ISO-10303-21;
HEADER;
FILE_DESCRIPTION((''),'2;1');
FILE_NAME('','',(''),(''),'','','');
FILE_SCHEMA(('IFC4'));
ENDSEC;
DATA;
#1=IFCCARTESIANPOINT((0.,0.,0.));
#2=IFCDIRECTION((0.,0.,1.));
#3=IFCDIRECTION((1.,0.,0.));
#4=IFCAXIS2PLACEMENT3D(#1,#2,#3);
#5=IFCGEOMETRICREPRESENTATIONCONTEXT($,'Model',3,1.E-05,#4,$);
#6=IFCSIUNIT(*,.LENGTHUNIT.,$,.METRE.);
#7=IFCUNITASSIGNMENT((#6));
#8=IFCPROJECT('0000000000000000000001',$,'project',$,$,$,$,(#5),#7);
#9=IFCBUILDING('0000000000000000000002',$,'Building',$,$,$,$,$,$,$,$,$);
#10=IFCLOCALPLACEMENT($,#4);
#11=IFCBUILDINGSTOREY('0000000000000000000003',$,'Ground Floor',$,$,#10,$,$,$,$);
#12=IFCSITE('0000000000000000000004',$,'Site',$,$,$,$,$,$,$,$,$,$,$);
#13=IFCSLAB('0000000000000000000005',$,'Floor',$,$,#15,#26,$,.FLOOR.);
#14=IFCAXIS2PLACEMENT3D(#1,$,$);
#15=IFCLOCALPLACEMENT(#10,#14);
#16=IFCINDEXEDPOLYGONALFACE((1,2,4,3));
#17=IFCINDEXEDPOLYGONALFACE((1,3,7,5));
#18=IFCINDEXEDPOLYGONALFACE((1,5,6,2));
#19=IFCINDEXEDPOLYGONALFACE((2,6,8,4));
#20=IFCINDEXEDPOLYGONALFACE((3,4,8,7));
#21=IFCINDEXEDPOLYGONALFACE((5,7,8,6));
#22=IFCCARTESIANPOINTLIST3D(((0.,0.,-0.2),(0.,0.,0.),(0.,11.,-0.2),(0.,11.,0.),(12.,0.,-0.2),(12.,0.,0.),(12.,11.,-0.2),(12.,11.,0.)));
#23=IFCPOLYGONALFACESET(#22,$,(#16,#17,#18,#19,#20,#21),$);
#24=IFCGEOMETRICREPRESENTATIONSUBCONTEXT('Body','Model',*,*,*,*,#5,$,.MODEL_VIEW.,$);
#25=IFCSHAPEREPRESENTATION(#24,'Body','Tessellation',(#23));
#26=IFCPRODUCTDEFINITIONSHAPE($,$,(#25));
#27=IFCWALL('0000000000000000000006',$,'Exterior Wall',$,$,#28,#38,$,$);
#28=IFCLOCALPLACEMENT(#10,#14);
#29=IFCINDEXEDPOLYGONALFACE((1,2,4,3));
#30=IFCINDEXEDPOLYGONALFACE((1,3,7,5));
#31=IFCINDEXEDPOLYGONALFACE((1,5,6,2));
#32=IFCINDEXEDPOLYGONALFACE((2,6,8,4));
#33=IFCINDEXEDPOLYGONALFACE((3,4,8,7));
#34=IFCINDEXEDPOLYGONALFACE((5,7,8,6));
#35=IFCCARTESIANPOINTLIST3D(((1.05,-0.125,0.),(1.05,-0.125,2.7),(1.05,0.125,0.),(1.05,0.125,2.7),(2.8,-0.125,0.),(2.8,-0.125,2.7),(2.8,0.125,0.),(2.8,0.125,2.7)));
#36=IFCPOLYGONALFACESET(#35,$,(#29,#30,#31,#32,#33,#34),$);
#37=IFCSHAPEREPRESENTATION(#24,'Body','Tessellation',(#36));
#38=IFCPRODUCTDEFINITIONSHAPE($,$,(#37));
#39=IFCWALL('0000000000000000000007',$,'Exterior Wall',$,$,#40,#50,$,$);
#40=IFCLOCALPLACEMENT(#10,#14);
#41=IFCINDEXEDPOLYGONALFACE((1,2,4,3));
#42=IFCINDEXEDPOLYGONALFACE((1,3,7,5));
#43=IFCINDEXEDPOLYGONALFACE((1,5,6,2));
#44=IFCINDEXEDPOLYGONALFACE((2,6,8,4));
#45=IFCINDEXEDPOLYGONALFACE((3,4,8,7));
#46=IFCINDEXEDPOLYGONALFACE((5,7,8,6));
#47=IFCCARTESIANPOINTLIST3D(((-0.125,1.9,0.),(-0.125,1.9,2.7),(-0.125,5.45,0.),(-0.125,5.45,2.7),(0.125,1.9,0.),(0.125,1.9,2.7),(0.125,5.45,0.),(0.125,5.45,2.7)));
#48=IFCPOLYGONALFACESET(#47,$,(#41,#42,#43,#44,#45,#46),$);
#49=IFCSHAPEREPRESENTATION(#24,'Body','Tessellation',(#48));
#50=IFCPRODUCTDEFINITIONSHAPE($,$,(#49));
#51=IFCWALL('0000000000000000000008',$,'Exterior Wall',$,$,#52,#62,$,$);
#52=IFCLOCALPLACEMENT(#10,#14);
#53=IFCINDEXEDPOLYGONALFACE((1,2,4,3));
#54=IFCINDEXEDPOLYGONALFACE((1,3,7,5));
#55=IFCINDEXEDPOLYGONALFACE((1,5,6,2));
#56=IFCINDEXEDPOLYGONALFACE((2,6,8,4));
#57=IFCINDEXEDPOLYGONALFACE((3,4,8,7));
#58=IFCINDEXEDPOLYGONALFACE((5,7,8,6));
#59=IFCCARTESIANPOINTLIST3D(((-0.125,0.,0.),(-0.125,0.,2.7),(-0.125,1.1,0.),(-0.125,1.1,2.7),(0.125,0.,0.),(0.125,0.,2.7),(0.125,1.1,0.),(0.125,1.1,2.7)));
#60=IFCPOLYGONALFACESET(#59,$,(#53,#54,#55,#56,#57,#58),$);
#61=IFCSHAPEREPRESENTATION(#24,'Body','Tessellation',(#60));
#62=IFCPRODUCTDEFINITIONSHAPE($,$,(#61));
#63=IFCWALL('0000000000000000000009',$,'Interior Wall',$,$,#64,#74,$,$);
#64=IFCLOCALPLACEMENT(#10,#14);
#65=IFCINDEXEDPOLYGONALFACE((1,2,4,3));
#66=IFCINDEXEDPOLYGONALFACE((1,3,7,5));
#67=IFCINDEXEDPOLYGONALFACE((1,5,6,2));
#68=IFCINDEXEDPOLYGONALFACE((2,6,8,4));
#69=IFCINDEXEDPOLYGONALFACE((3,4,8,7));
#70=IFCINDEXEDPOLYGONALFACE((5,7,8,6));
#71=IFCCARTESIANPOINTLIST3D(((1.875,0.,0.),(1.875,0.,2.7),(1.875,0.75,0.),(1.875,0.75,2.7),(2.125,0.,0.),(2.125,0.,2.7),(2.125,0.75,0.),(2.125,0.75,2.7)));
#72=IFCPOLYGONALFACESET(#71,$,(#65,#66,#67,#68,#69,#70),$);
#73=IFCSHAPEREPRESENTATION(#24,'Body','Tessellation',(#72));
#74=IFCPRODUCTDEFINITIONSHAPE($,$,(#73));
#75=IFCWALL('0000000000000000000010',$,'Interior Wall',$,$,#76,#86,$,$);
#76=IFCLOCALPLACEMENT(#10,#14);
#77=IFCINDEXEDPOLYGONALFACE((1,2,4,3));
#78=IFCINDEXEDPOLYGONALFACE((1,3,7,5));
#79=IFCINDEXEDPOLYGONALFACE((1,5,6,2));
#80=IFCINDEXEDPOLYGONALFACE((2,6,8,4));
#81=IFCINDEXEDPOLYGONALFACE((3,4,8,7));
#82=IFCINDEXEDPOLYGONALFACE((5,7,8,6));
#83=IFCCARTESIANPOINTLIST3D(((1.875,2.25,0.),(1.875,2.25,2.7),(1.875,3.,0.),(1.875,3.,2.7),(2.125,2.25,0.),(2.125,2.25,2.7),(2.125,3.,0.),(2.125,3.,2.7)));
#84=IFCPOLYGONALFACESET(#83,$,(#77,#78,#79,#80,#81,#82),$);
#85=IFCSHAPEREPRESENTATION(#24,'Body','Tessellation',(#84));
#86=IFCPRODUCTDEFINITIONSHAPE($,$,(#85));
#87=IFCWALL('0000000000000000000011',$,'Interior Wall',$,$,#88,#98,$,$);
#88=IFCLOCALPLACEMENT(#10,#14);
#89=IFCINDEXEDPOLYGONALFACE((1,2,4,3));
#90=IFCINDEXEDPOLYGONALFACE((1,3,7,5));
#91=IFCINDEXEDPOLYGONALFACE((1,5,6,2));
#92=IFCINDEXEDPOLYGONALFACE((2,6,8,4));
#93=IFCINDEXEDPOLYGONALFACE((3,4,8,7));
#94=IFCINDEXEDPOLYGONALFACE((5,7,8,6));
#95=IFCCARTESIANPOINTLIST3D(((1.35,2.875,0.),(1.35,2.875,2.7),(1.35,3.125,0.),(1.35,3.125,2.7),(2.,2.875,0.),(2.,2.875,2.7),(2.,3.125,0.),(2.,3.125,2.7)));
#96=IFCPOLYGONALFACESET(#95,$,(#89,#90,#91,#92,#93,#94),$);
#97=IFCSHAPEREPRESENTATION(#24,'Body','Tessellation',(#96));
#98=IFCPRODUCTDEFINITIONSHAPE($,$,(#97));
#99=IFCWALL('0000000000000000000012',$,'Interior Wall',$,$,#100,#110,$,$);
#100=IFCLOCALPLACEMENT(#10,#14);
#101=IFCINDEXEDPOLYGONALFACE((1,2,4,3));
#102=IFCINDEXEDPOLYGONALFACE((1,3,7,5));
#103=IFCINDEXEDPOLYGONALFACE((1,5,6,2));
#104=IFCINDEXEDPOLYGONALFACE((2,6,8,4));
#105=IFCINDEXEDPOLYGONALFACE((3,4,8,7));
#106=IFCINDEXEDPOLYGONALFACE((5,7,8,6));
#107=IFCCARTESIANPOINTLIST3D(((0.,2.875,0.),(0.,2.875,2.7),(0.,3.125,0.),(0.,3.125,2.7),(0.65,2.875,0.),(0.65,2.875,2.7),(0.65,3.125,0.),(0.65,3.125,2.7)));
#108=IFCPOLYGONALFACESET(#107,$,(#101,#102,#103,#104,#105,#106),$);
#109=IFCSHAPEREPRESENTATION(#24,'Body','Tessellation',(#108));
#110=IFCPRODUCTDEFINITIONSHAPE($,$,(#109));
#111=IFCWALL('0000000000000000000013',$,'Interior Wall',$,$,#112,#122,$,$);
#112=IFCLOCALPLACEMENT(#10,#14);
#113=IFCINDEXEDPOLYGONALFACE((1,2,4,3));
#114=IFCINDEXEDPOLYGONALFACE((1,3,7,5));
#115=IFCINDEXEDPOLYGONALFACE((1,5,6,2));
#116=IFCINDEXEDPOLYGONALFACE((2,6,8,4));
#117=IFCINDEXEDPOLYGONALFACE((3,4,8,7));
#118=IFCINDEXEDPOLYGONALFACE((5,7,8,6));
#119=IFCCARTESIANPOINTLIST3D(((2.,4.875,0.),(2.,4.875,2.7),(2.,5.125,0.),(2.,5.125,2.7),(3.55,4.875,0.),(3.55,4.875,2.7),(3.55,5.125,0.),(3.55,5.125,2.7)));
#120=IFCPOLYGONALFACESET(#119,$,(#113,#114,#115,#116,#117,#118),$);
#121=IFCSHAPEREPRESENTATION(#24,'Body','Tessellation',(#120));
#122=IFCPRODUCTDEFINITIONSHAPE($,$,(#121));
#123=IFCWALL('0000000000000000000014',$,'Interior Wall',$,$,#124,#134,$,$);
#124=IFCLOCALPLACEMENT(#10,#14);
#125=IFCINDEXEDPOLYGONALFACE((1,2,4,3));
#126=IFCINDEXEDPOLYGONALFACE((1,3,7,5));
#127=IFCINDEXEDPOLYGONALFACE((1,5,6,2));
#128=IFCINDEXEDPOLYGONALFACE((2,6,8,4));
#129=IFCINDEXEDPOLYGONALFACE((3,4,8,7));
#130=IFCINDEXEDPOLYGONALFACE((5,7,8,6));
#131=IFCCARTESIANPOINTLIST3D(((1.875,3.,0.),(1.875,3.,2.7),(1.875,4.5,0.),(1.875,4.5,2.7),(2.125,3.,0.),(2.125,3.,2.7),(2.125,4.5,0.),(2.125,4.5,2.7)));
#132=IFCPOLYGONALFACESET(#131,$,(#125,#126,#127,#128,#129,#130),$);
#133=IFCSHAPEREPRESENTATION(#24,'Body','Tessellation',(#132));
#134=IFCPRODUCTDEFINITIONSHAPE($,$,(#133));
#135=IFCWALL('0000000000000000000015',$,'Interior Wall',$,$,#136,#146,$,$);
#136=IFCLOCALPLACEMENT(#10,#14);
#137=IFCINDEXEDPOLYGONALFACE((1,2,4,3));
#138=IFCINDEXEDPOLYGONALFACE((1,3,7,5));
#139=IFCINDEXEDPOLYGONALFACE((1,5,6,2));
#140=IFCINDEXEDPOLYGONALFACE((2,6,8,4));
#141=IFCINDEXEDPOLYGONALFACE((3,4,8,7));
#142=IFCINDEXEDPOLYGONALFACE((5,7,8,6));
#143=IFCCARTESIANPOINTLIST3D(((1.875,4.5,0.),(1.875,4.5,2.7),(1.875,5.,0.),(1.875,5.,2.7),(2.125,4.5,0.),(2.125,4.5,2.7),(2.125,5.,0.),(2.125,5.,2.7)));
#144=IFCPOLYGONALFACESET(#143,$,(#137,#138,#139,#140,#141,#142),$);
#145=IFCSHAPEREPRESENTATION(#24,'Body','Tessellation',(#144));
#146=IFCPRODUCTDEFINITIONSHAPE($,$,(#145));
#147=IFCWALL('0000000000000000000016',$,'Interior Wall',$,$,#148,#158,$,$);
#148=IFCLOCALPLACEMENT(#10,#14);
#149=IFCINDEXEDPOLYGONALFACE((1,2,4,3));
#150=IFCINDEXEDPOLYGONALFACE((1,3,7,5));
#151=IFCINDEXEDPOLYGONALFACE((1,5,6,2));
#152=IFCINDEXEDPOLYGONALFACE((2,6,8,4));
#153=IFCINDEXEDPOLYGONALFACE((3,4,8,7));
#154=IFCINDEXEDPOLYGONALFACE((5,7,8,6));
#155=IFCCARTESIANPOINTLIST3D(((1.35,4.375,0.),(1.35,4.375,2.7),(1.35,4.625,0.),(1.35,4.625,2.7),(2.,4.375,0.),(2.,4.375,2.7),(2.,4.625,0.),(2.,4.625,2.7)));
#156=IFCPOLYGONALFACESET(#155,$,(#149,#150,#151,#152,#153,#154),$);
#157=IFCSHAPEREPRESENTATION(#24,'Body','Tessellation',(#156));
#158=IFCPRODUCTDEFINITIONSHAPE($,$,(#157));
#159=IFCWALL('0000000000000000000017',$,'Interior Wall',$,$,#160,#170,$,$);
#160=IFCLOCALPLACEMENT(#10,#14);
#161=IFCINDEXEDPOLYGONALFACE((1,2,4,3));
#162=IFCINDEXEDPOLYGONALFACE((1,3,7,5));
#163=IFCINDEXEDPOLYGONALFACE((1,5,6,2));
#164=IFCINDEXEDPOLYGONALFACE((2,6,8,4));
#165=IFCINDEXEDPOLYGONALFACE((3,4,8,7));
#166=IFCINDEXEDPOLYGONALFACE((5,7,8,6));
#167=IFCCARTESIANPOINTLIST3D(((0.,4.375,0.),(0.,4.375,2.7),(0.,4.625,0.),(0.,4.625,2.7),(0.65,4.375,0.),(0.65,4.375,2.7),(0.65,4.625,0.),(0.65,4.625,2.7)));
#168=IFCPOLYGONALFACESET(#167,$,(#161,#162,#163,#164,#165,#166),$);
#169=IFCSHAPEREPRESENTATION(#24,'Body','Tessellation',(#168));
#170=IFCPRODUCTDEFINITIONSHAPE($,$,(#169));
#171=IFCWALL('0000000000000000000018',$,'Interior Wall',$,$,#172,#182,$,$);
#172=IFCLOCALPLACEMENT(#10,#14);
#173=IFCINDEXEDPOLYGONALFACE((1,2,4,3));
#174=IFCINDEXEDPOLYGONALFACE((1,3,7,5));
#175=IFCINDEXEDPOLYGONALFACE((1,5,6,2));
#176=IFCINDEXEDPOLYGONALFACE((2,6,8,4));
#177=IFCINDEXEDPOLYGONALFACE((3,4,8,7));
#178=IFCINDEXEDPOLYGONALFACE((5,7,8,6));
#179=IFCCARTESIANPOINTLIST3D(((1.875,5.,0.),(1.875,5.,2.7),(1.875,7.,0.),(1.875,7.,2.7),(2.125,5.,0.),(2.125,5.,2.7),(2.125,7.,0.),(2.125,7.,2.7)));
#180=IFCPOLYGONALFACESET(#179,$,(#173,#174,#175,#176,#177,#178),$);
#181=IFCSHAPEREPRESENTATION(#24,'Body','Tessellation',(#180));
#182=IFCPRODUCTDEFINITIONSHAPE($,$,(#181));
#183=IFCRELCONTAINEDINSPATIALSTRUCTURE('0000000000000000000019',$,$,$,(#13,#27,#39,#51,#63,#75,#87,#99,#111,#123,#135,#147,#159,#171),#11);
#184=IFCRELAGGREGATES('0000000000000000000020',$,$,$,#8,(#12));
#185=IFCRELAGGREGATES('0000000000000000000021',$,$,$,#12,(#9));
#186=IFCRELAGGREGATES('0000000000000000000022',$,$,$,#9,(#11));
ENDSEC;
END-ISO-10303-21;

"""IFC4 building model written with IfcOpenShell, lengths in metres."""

from ifc_helpers import new_model, si_unit, frame, origin_with_axes, place, context, subcontext, project, spatial, indexed_curve, outline, extrude, element, save


model = new_model("IFC4")

# Units and contexts
model_context = context("Model", 3, precision=1e-05, world=origin_with_axes())
body_context = subcontext(model_context, "Body", "Model", "MODEL_VIEW")
ifc_project = project(units=[si_unit("LENGTHUNIT", "METRE")], contexts=[model_context])

# Site, building, storey
site = spatial("IfcSite", under=ifc_project, Name="Site")
building = spatial("IfcBuilding", under=site, Name="Building")
storey_placement = place(None, origin_with_axes())
storey = spatial("IfcBuildingStorey", under=building, at=storey_placement, Name="Ground Floor")

# Slab
slab_placement = place(storey_placement, frame((0.0, 0.0, -0.2), z_axis=(0.0, 0.0, 1.0), x_axis=(1.0, 0.0, 0.0)))
element("IfcSlab", 1, at=slab_placement, inside=storey, Name="Floor", PredefinedType="FLOOR", context=body_context, shape_type="SweptSolid", body=[
    extrude(outline(indexed_curve([(0.0, 0.0), (12.0, 0.0), (12.0, 11.0), (0.0, 11.0)])), None, (0.0, 0.0, 1.0), 0.2),
])

# Walls
wall_1_placement = place(storey_placement, frame((1.05, 0.0, 0.0), z_axis=(0.0, 0.0, 1.0), x_axis=(1.0, 0.0, 0.0)))
element("IfcWall", 2, at=wall_1_placement, inside=storey, Name="Exterior Wall", context=body_context, shape_type="SweptSolid", body=[
    extrude(outline(indexed_curve([(0.0, 0.0), (0.0, 0.25), (1.75, 0.25), (1.75, 0.0), (0.0, 0.0)], self_intersect=False)), frame((0.0, -0.125, 0.0), z_axis=(0.0, 0.0, 1.0), x_axis=(1.0, 0.0, 0.0)), (0.0, 0.0, 1.0), 2.7),
])
wall_2_placement = place(storey_placement, frame((0.0, 5.45, 0.0), z_axis=(0.0, 0.0, 1.0), x_axis=(0.0, -1.0, 0.0)))
element("IfcWall", 3, at=wall_2_placement, inside=storey, Name="Exterior Wall", context=body_context, shape_type="SweptSolid", body=[
    extrude(outline(indexed_curve([(0.0, 0.0), (0.0, 0.25), (3.55, 0.25), (3.55, 0.0), (0.0, 0.0)], self_intersect=False)), frame((0.0, -0.125, 0.0), z_axis=(0.0, 0.0, 1.0), x_axis=(1.0, 0.0, 0.0)), (0.0, 0.0, 1.0), 2.7),
])
wall_3_placement = place(storey_placement, frame((0.0, 1.1, 0.0), z_axis=(0.0, 0.0, 1.0), x_axis=(0.0, -1.0, 0.0)))
element("IfcWall", 4, at=wall_3_placement, inside=storey, Name="Exterior Wall", context=body_context, shape_type="SweptSolid", body=[
    extrude(outline(indexed_curve([(0.0, 0.0), (0.0, 0.25), (1.1, 0.25), (1.1, 0.0), (0.0, 0.0)], self_intersect=False)), frame((0.0, -0.125, 0.0), z_axis=(0.0, 0.0, 1.0), x_axis=(1.0, 0.0, 0.0)), (0.0, 0.0, 1.0), 2.7),
])
for number, where, z_axis, x_axis, name in (
    (5, (2.0, 0.0, 0.0), (0.0, 0.0, 1.0), (0.0, 1.0, 0.0), "Interior Wall"),
    (6, (2.0, 2.25, 0.0), (0.0, 0.0, 1.0), (0.0, 1.0, 0.0), "Interior Wall"),
):
    element("IfcWall", number, at=place(storey_placement, frame(where, z_axis=z_axis, x_axis=x_axis)), inside=storey, Name=name, context=body_context, shape_type="SweptSolid", body=[
        extrude(outline(indexed_curve([(0.0, 0.0), (0.0, 0.25), (0.75, 0.25), (0.75, 0.0), (0.0, 0.0)], self_intersect=False)), frame((0.0, -0.125, 0.0), z_axis=(0.0, 0.0, 1.0), x_axis=(1.0, 0.0, 0.0)), (0.0, 0.0, 1.0), 2.7),
    ])
for number, where, z_axis, x_axis, name in (
    (7, (2.0, 3.0, 0.0), (0.0, 0.0, 1.0), (-1.0, 0.0, 0.0), "Interior Wall"),
    (8, (0.65, 3.0, 0.0), (0.0, 0.0, 1.0), (-1.0, 0.0, 0.0), "Interior Wall"),
):
    element("IfcWall", number, at=place(storey_placement, frame(where, z_axis=z_axis, x_axis=x_axis)), inside=storey, Name=name, context=body_context, shape_type="SweptSolid", body=[
        extrude(outline(indexed_curve([(0.0, 0.0), (0.0, 0.25), (0.65, 0.25), (0.65, 0.0), (0.0, 0.0)], self_intersect=False)), frame((0.0, -0.125, 0.0), z_axis=(0.0, 0.0, 1.0), x_axis=(1.0, 0.0, 0.0)), (0.0, 0.0, 1.0), 2.7),
    ])
wall_4_placement = place(storey_placement, frame((3.55, 5.0, 0.0), z_axis=(0.0, 0.0, 1.0), x_axis=(-1.0, 0.0, 0.0)))
element("IfcWall", 9, at=wall_4_placement, inside=storey, Name="Interior Wall", context=body_context, shape_type="SweptSolid", body=[
    extrude(outline(indexed_curve([(0.0, 0.0), (0.0, 0.25), (1.55, 0.25), (1.55, 0.0), (0.0, 0.0)], self_intersect=False)), frame((0.0, -0.125, 0.0), z_axis=(0.0, 0.0, 1.0), x_axis=(1.0, 0.0, 0.0)), (0.0, 0.0, 1.0), 2.7),
])
wall_5_placement = place(storey_placement, frame((2.0, 4.5, 0.0), z_axis=(0.0, 0.0, 1.0), x_axis=(0.0, -1.0, 0.0)))
element("IfcWall", 10, at=wall_5_placement, inside=storey, Name="Interior Wall", context=body_context, shape_type="SweptSolid", body=[
    extrude(outline(indexed_curve([(0.0, 0.0), (0.0, 0.25), (1.5, 0.25), (1.5, 0.0), (0.0, 0.0)], self_intersect=False)), frame((0.0, -0.125, 0.0), z_axis=(0.0, 0.0, 1.0), x_axis=(1.0, 0.0, 0.0)), (0.0, 0.0, 1.0), 2.7),
])
wall_6_placement = place(storey_placement, frame((2.0, 5.0, 0.0), z_axis=(0.0, 0.0, 1.0), x_axis=(0.0, -1.0, 0.0)))
element("IfcWall", 11, at=wall_6_placement, inside=storey, Name="Interior Wall", context=body_context, shape_type="SweptSolid", body=[
    extrude(outline(indexed_curve([(0.0, 0.0), (0.0, 0.25), (0.5, 0.25), (0.5, 0.0), (0.0, 0.0)], self_intersect=False)), frame((0.0, -0.125, 0.0), z_axis=(0.0, 0.0, 1.0), x_axis=(1.0, 0.0, 0.0)), (0.0, 0.0, 1.0), 2.7),
])
for number, where, z_axis, x_axis, name in (
    (12, (2.0, 4.5, 0.0), (0.0, 0.0, 1.0), (-1.0, 0.0, 0.0), "Interior Wall"),
    (13, (0.65, 4.5, 0.0), (0.0, 0.0, 1.0), (-1.0, 0.0, 0.0), "Interior Wall"),
):
    element("IfcWall", number, at=place(storey_placement, frame(where, z_axis=z_axis, x_axis=x_axis)), inside=storey, Name=name, context=body_context, shape_type="SweptSolid", body=[
        extrude(outline(indexed_curve([(0.0, 0.0), (0.0, 0.25), (0.65, 0.25), (0.65, 0.0), (0.0, 0.0)], self_intersect=False)), frame((0.0, -0.125, 0.0), z_axis=(0.0, 0.0, 1.0), x_axis=(1.0, 0.0, 0.0)), (0.0, 0.0, 1.0), 2.7),
    ])
wall_7_placement = place(storey_placement, frame((2.0, 5.0, 0.0), z_axis=(0.0, 0.0, 1.0), x_axis=(0.0, 1.0, 0.0)))
element("IfcWall", 14, at=wall_7_placement, inside=storey, Name="Interior Wall", context=body_context, shape_type="SweptSolid", body=[
    extrude(outline(indexed_curve([(0.0, 0.0), (0.0, 0.25), (2.0, 0.25), (2.0, 0.0), (0.0, 0.0)], self_intersect=False)), frame((0.0, -0.125, 0.0), z_axis=(0.0, 0.0, 1.0), x_axis=(1.0, 0.0, 0.0)), (0.0, 0.0, 1.0), 2.7),
])

save(model, "model.ifc")
